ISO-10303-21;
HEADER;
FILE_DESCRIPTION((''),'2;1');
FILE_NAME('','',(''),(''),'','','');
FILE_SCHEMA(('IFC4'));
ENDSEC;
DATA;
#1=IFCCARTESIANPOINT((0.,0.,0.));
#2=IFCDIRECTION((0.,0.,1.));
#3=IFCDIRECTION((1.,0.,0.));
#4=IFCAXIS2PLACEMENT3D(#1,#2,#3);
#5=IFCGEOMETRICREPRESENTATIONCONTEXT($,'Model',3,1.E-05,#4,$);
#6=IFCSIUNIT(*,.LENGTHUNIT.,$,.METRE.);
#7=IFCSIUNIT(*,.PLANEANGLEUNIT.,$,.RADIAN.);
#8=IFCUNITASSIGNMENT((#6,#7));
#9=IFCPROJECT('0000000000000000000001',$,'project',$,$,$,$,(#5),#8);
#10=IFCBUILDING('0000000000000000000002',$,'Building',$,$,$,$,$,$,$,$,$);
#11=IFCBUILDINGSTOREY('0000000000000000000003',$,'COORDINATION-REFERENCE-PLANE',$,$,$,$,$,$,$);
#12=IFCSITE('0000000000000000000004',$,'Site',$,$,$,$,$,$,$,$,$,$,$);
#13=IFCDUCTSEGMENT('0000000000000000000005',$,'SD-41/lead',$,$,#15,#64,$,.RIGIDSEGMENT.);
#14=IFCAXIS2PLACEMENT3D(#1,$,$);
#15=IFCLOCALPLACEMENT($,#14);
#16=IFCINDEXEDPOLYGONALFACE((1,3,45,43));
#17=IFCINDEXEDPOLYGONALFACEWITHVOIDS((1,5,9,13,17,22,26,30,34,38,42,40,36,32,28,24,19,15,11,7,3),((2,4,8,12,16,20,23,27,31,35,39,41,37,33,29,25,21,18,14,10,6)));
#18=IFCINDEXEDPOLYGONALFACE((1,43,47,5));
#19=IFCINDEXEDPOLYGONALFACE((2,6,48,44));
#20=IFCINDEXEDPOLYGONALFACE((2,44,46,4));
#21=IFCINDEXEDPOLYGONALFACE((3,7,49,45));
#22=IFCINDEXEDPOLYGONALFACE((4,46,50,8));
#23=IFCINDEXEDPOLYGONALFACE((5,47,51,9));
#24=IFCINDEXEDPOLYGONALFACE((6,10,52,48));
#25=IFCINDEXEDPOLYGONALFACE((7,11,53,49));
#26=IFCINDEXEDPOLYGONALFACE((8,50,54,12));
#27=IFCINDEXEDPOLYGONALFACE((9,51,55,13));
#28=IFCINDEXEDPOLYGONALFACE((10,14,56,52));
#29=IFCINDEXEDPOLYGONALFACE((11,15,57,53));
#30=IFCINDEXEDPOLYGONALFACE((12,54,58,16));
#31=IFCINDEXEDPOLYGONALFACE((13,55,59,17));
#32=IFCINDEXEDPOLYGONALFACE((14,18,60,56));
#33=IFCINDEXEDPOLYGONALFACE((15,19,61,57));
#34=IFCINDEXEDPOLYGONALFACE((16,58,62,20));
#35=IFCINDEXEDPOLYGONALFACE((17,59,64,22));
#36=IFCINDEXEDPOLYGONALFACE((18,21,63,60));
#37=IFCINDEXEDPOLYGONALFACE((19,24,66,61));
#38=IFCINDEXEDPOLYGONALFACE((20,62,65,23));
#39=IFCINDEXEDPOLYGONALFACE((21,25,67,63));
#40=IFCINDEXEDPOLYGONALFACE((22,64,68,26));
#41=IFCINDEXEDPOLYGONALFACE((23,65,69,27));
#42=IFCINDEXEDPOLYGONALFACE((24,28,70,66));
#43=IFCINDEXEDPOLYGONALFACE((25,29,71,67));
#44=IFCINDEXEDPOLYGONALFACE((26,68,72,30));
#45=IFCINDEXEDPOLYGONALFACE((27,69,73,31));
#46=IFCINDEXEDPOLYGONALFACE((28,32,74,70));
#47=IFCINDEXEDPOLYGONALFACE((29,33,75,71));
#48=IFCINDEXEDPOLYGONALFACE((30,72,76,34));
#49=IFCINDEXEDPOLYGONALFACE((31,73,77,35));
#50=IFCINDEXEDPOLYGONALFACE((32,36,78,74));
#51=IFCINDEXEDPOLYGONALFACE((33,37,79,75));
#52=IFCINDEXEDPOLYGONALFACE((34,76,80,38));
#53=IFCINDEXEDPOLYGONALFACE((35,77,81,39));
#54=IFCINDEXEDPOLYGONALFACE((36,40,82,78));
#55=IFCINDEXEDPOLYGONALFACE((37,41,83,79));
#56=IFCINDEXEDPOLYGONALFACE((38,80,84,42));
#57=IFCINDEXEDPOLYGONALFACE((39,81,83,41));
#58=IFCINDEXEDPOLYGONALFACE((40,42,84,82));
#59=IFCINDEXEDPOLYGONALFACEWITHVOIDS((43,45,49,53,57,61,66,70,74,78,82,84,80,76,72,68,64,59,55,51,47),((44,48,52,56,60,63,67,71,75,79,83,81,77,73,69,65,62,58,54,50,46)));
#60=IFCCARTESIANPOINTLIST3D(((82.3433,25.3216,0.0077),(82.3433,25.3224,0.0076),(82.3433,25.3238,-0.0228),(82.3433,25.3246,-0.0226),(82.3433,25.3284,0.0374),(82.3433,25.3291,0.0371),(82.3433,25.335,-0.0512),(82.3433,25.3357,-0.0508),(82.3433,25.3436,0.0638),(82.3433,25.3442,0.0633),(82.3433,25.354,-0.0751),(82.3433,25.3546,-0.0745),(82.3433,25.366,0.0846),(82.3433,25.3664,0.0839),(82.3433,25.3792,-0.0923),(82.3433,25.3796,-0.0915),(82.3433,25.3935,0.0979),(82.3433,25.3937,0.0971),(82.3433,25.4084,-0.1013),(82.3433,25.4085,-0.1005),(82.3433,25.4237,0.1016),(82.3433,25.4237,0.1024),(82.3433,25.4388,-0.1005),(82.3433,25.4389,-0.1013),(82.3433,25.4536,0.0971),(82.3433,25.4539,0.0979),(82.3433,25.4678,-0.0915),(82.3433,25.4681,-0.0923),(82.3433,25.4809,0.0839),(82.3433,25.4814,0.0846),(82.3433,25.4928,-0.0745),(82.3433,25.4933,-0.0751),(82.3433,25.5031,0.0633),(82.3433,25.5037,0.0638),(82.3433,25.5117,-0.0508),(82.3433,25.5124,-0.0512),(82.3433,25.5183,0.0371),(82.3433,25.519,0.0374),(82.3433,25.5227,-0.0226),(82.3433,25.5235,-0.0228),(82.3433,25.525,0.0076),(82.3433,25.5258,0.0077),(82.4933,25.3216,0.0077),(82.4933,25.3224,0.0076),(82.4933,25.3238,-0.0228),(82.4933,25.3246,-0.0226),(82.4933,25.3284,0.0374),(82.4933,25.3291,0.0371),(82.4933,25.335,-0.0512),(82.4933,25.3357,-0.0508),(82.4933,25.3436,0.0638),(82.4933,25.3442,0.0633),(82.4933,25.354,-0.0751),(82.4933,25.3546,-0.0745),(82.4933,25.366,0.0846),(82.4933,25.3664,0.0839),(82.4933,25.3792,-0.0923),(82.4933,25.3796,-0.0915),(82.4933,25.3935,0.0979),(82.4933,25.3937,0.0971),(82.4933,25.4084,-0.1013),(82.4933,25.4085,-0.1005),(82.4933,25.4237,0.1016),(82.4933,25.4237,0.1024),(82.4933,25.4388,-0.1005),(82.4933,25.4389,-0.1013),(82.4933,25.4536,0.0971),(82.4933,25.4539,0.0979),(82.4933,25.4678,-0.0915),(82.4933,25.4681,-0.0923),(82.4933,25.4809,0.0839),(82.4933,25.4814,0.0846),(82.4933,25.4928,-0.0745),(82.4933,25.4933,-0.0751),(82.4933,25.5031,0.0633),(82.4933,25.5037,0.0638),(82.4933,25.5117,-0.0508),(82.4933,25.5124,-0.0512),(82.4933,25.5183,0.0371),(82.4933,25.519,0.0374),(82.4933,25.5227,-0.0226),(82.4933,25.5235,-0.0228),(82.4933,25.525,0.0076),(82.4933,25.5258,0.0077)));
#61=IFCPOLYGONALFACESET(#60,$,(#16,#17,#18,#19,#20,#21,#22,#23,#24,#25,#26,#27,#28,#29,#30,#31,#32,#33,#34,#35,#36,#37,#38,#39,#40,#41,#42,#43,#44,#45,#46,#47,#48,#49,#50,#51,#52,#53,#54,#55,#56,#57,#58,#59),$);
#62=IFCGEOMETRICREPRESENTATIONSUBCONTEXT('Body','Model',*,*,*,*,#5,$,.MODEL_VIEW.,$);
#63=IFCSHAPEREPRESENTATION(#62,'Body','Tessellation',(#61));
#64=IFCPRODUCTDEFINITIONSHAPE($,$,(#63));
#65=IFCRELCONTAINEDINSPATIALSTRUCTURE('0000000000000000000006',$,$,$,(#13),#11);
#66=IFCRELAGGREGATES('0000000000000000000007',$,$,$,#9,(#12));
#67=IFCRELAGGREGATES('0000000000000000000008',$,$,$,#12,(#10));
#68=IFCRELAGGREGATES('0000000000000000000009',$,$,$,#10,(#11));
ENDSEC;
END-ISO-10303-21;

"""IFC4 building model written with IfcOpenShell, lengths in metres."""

from ifc_helpers import new_model, si_unit, frame, origin_with_axes, place, context, subcontext, project, spatial, hollow_circle, extrude, element, save


model = new_model("IFC4")

# Units and contexts
model_context_1 = context("Model", 3, precision=1e-05, world=origin_with_axes())
body_context_1 = subcontext(model_context_1, "Body", "Model", "MODEL_VIEW")
ifc_project = project(units=[si_unit("LENGTHUNIT", "METRE"), si_unit("PLANEANGLEUNIT", "RADIAN")], contexts=[model_context_1])

# Site, building, storey
site = spatial("IfcSite", under=ifc_project, Name="Site")
building = spatial("IfcBuilding", under=site, Name="Building")
storey = spatial("IfcBuildingStorey", under=building, Name="COORDINATION-REFERENCE-PLANE")

# Duct segment
duct_segment_1_placement = place(None, frame((82.4933, 25.4237, 0.0), z_axis=(-1.0, 0.0, 0.0), x_axis=(0.0, 0.0, 1.0)))
element("IfcDuctSegment", 1, at=duct_segment_1_placement, inside=storey, Name="SD-41/lead", PredefinedType="RIGIDSEGMENT", context=body_context_1, shape_type="SweptSolid", body=[
    extrude(hollow_circle(Radius=0.1024, WallThickness=0.0008), origin_with_axes(), (0.0, 0.0, 1.0), 0.15),
])

save(model, "model.ifc")
